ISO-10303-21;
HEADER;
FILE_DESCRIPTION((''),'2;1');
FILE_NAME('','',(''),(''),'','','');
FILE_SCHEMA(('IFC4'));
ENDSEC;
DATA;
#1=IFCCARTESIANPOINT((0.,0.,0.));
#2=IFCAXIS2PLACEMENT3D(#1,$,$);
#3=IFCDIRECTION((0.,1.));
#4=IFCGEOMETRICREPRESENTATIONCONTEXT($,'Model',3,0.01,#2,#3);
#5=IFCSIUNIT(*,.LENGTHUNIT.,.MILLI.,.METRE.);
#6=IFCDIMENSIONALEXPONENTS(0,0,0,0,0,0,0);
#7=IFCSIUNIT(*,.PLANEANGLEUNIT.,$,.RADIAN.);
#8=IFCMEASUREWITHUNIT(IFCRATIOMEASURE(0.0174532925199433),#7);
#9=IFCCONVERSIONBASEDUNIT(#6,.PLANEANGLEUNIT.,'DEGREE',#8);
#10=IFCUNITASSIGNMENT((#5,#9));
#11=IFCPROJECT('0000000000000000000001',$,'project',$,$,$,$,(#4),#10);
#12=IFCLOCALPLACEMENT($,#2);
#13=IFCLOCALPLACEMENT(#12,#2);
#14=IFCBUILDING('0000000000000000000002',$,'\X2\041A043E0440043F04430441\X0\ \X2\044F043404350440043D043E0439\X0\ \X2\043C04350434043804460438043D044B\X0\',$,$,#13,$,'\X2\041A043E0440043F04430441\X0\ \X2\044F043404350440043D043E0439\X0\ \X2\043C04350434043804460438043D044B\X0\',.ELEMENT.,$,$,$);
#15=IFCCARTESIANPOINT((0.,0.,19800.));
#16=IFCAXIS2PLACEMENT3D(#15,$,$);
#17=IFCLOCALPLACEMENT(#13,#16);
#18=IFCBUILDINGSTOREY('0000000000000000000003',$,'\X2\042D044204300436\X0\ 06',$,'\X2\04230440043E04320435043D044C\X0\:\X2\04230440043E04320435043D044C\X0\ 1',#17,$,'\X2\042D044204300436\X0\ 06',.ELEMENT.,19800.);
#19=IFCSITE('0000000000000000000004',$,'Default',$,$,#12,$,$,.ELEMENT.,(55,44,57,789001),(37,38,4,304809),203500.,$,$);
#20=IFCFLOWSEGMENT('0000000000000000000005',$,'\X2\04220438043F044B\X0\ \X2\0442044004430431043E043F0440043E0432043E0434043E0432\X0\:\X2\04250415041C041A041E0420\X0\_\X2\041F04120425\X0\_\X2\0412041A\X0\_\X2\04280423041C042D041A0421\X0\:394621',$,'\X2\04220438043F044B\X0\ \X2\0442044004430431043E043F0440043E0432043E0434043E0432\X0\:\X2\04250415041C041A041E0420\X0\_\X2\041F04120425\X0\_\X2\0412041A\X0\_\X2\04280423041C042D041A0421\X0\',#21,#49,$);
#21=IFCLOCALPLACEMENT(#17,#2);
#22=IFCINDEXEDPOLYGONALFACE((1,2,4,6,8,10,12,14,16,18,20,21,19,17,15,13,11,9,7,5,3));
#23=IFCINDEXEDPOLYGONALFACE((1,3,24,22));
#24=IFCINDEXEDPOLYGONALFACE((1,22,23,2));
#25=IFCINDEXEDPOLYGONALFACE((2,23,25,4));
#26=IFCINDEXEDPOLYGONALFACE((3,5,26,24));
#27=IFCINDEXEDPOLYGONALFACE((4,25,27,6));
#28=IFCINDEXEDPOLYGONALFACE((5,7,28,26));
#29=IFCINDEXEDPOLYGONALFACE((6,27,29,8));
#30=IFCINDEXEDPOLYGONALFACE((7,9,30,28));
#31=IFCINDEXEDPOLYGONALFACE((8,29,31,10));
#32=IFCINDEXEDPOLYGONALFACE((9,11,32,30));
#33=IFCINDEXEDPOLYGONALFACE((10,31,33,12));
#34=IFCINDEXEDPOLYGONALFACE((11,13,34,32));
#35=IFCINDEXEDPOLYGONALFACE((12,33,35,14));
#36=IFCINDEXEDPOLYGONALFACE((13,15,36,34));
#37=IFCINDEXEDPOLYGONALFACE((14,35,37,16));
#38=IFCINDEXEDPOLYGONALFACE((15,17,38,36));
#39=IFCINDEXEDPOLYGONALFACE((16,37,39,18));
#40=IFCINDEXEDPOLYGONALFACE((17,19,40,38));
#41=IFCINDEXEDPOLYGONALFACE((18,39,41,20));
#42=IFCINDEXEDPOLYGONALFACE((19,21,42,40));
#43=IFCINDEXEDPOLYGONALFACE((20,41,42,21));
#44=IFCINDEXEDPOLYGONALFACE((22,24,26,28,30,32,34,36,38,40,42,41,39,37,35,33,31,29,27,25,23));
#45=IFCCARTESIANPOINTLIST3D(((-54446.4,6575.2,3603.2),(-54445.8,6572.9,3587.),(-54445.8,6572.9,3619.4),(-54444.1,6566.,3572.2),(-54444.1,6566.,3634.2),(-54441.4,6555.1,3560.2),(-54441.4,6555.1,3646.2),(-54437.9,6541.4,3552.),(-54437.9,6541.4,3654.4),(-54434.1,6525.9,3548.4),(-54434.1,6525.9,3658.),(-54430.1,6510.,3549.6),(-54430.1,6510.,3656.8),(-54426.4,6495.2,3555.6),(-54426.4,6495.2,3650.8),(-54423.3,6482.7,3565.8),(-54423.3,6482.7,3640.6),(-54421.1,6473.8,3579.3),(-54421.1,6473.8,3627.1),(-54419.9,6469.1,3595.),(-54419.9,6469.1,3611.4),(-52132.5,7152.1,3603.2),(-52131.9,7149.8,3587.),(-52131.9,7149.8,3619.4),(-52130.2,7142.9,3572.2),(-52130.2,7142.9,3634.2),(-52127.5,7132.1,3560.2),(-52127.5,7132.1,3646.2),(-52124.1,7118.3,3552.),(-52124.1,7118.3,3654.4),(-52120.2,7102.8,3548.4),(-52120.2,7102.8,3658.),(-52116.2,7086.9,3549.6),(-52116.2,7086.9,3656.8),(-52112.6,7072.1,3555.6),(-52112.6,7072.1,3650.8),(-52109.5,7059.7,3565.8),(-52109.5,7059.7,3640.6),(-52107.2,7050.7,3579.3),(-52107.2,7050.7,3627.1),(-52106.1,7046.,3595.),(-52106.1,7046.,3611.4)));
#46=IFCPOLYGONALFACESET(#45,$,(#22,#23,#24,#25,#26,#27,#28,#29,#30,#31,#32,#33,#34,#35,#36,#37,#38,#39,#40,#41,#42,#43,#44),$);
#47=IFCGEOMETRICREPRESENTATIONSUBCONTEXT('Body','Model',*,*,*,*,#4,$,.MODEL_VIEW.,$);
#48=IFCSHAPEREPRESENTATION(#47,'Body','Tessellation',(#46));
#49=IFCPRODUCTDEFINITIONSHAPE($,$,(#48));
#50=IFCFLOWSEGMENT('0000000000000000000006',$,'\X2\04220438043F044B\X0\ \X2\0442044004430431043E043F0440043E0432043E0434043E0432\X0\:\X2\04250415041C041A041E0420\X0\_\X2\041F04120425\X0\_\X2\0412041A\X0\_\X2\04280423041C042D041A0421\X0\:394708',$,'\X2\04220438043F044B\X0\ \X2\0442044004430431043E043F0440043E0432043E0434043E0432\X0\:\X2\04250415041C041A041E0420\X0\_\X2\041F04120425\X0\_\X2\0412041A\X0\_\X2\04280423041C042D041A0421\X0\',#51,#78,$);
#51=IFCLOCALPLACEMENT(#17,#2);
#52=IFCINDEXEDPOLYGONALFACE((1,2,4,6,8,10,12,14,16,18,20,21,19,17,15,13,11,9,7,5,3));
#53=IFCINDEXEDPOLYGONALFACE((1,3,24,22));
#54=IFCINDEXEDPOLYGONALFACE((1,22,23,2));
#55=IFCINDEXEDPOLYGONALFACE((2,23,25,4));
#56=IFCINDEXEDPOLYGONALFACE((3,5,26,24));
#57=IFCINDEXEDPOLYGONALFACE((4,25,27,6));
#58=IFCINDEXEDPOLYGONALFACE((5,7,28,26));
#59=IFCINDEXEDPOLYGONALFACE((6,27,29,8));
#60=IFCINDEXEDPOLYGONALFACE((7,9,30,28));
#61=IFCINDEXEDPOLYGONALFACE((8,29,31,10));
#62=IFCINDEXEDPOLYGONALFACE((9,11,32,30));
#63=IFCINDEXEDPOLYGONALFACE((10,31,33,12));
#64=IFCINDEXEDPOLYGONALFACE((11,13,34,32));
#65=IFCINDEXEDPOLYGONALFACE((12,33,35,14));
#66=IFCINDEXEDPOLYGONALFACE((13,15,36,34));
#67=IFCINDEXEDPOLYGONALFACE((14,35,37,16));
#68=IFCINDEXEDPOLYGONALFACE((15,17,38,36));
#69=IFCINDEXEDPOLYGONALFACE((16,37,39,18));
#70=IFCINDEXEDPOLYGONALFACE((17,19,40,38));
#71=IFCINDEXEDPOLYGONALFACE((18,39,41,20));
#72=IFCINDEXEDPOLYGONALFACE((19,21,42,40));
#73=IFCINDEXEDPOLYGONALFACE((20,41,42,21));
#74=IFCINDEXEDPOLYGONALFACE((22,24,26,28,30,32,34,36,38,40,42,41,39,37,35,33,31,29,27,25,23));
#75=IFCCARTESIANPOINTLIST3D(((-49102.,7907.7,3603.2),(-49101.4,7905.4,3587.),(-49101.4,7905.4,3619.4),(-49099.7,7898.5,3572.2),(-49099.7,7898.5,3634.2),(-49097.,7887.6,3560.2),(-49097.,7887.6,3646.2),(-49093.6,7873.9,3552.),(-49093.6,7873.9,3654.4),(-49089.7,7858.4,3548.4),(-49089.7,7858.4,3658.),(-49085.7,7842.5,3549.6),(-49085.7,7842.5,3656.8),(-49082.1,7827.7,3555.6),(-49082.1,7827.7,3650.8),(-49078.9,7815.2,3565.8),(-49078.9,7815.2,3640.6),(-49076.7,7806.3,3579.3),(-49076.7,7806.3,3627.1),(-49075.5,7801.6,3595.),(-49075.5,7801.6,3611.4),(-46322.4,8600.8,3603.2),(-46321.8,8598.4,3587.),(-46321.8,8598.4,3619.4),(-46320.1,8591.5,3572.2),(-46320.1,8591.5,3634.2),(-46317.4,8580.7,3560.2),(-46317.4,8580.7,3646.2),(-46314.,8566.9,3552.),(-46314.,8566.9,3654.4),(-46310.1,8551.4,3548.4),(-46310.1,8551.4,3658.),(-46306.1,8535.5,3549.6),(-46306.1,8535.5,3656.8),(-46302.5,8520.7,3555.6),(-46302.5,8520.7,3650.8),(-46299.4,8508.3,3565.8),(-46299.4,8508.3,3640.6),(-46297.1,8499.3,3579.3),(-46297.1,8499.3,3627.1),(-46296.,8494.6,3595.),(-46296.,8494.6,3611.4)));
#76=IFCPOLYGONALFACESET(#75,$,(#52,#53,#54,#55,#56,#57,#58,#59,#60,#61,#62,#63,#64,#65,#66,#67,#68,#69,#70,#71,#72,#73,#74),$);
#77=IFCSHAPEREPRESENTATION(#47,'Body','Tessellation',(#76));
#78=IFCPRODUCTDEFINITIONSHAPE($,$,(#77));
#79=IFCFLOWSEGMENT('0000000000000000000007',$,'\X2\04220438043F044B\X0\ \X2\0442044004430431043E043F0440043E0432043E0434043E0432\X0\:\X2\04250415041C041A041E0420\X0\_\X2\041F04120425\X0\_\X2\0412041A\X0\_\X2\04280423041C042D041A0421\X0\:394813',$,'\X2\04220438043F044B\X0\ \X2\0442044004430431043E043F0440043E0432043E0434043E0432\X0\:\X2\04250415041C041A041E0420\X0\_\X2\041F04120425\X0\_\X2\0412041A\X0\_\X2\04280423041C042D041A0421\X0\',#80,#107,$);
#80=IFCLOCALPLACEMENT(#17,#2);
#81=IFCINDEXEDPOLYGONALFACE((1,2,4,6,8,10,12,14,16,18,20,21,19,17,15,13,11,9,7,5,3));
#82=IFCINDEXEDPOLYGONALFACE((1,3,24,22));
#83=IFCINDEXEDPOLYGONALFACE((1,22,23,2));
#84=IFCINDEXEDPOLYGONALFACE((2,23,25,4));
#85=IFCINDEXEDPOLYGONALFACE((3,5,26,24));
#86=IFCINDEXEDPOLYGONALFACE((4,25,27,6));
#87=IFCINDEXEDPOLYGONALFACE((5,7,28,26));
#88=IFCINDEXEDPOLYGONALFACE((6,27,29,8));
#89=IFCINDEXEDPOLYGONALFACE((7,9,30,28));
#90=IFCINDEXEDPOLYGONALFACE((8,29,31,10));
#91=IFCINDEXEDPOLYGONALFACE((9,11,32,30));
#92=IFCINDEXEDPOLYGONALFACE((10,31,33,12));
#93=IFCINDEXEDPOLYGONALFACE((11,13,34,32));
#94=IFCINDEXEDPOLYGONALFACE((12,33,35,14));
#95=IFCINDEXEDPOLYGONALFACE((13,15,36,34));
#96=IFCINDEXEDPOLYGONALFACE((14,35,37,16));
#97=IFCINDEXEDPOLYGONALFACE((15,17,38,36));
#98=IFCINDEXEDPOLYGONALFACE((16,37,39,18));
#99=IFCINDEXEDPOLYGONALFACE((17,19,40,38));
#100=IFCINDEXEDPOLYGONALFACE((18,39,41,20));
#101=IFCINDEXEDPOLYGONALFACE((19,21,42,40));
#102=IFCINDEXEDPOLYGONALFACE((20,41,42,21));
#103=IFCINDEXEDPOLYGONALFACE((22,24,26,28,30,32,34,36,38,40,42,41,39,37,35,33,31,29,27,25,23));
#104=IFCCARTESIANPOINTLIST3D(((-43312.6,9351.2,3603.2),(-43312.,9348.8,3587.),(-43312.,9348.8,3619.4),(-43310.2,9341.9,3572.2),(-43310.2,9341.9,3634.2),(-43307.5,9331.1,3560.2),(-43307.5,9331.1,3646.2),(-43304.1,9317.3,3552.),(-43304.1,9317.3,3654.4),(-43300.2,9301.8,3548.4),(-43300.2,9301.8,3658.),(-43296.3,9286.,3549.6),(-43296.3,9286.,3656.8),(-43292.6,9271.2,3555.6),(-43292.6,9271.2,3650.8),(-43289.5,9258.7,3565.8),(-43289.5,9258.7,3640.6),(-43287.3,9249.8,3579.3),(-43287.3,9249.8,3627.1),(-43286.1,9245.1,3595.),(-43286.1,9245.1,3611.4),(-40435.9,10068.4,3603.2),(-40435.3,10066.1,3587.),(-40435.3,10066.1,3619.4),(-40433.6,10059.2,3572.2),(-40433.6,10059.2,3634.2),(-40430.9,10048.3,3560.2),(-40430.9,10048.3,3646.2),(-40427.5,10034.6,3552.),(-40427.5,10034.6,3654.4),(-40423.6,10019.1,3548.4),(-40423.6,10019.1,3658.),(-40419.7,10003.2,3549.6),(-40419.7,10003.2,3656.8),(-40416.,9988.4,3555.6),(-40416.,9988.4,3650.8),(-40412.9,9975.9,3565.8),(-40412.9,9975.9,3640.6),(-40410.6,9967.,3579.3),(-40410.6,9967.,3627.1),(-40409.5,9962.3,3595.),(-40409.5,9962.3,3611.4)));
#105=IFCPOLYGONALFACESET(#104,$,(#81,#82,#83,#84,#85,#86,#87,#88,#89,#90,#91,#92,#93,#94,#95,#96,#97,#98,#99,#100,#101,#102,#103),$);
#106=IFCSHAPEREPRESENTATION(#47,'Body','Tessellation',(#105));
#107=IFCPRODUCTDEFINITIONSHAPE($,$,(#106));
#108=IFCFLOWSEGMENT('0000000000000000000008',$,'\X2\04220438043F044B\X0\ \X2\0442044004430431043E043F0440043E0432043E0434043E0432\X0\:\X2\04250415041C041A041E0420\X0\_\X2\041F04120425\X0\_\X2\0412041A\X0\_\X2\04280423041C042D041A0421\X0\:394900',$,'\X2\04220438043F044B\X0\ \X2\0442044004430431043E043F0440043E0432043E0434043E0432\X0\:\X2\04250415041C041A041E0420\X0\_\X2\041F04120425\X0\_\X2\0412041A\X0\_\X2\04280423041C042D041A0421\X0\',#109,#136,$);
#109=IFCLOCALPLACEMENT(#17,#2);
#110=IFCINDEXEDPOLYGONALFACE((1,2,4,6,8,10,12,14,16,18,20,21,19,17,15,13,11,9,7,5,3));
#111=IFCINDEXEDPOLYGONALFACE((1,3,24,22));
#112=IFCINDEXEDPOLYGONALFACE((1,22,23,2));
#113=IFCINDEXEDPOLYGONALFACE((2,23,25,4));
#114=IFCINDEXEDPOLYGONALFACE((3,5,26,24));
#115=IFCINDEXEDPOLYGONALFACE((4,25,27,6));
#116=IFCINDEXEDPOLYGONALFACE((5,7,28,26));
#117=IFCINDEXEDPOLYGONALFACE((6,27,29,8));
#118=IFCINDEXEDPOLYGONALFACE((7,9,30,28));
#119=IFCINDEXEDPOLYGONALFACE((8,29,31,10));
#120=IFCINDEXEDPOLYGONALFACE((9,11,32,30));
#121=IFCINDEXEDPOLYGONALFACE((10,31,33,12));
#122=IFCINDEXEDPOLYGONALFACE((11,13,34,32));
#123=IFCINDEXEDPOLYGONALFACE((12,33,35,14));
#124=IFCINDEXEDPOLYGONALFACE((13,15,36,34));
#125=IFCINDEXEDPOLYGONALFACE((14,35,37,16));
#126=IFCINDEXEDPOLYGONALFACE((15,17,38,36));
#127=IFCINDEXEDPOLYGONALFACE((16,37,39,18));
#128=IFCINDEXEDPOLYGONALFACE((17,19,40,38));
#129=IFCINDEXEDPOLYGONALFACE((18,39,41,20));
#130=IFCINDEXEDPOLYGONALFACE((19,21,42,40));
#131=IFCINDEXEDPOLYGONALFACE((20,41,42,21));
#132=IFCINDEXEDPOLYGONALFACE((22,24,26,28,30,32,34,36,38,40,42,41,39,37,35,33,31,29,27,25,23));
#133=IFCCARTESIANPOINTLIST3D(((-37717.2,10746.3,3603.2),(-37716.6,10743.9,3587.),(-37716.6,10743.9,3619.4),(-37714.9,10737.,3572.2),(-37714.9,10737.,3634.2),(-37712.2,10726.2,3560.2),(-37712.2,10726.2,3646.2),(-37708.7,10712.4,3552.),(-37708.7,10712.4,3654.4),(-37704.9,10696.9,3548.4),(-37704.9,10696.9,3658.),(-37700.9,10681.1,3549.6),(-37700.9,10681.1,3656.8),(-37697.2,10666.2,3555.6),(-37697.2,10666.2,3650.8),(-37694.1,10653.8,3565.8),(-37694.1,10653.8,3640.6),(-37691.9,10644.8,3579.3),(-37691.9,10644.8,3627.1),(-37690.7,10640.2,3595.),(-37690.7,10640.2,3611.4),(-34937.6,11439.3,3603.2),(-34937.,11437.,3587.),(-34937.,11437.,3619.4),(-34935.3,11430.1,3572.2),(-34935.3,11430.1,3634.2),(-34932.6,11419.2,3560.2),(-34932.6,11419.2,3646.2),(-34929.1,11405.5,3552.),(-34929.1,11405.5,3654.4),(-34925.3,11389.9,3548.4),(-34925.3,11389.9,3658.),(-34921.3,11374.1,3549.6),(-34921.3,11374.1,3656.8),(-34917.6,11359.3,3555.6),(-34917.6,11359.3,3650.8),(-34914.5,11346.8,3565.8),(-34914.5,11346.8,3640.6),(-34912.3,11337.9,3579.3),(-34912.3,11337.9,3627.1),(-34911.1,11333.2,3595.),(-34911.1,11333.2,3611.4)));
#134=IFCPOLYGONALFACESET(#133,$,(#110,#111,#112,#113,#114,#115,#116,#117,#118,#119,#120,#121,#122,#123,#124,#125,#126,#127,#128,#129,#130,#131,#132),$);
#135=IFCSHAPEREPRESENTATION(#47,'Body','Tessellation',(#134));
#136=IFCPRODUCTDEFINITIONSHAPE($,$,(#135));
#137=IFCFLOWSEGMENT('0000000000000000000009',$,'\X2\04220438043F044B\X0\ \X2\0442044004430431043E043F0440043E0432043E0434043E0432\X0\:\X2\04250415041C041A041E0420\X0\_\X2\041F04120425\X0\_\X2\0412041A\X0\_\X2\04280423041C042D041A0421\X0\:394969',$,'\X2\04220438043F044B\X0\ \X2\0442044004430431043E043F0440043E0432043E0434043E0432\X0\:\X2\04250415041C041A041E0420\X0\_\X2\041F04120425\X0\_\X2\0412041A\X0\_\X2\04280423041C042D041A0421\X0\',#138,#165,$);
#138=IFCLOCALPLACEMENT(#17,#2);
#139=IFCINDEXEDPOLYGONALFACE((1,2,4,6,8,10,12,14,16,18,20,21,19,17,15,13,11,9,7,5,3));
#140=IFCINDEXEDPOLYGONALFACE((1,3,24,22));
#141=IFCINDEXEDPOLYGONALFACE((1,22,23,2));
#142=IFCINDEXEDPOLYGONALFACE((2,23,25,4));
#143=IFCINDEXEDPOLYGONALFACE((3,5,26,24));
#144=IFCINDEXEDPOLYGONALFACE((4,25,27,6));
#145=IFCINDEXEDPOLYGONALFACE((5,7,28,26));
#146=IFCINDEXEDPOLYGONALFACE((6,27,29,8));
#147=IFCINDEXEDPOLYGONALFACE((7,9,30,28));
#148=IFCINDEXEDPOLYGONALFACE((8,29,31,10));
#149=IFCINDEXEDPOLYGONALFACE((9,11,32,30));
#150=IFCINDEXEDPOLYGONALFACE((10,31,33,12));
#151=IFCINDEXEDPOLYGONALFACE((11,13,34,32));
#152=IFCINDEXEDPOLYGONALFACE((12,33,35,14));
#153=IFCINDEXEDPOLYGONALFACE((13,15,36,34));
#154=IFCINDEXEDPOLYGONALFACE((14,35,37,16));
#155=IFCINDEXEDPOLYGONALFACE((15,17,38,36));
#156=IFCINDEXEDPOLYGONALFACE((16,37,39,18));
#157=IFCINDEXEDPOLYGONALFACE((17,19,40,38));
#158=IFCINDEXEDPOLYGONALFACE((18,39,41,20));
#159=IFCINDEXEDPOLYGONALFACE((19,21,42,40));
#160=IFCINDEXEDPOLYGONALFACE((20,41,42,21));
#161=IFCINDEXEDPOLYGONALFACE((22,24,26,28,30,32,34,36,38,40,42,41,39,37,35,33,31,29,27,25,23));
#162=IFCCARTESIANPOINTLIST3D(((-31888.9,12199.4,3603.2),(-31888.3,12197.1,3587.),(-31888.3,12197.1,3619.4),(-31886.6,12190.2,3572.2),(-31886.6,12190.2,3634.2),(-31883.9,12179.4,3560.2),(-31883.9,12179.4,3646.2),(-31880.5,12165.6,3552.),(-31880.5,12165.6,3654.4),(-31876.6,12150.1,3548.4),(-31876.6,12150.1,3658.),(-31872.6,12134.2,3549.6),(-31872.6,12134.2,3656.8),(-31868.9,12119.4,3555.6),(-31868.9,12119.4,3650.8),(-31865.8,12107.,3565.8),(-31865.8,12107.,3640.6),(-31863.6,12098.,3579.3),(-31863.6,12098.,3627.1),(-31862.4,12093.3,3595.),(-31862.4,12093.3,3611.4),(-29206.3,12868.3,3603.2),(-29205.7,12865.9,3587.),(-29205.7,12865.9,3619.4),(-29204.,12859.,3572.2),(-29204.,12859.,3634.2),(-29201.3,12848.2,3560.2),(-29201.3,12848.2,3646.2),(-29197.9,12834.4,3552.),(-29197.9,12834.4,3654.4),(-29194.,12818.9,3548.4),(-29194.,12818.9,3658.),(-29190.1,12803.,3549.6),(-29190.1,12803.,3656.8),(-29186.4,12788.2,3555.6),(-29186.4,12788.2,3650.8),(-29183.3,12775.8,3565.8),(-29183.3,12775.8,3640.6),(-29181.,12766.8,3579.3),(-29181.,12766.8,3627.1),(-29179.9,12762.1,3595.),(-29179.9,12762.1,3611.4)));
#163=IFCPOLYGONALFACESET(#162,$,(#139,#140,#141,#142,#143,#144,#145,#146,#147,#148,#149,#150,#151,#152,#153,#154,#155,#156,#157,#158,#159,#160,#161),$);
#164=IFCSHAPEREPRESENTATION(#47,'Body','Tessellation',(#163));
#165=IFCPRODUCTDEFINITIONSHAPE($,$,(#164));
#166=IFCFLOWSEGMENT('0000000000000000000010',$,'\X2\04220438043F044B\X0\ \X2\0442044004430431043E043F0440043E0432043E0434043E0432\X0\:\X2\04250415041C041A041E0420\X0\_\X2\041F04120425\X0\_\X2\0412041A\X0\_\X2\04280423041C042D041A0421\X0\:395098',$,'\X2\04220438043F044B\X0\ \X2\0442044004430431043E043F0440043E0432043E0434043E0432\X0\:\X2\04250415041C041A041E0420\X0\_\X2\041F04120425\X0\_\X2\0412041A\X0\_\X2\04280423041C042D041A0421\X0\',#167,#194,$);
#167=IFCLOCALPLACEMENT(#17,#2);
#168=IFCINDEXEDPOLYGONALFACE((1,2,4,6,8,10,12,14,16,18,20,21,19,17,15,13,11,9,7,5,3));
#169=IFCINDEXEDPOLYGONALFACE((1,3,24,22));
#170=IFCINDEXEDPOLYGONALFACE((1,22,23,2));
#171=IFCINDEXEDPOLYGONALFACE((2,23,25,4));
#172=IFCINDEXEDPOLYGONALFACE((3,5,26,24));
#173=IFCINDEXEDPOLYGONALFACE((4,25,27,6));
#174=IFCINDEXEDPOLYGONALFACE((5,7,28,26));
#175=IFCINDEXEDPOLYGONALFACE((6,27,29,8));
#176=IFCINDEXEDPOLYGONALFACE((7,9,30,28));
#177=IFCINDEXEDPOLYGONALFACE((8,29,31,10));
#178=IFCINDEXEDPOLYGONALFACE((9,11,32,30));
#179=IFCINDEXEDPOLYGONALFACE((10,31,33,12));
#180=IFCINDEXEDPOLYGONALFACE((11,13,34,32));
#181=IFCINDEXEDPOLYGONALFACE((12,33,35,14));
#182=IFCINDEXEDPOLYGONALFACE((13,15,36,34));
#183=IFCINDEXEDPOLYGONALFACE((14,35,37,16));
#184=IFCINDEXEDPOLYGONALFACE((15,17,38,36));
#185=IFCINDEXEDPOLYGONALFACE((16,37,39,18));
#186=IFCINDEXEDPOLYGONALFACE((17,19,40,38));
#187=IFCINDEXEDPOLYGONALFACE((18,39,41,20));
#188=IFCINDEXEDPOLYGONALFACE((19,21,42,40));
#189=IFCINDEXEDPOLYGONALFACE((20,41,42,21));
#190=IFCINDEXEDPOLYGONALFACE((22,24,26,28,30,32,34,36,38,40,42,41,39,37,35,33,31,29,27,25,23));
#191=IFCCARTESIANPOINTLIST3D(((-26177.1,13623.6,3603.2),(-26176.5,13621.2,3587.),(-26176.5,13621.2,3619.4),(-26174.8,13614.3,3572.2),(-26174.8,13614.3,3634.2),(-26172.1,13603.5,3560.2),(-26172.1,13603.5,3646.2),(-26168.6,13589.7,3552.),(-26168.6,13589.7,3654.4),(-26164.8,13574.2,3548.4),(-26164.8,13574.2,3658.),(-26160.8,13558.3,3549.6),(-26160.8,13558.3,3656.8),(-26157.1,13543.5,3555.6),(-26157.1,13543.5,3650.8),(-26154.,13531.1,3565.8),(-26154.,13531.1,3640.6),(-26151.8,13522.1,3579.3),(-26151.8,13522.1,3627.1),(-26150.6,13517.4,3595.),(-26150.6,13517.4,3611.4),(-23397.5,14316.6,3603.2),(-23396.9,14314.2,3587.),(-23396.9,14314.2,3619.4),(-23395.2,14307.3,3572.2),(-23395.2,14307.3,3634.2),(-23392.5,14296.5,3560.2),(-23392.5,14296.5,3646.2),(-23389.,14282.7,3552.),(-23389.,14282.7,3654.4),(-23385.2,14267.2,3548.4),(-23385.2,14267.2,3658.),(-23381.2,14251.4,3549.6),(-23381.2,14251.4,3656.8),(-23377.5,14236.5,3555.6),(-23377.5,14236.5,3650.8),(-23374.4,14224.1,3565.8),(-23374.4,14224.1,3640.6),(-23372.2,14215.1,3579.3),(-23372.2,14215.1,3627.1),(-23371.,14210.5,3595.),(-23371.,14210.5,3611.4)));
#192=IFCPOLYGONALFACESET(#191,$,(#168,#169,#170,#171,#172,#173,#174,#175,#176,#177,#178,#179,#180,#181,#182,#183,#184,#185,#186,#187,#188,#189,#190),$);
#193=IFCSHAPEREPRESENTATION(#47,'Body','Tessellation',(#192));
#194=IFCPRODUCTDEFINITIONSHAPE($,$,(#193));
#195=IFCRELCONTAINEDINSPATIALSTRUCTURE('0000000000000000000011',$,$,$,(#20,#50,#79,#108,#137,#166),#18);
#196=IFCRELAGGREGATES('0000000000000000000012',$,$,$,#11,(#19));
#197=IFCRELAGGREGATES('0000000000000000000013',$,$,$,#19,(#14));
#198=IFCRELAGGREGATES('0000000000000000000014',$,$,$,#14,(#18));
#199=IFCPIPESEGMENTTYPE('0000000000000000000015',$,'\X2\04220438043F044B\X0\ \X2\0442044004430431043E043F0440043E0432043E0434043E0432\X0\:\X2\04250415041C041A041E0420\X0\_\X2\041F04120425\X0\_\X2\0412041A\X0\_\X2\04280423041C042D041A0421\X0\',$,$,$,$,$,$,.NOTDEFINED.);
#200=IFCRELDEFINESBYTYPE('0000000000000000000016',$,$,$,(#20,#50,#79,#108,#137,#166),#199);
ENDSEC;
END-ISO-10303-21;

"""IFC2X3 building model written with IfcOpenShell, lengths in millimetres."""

from ifc_helpers import new_model, entity, si_unit, converted_unit, direction, frame, frame_2d, origin, origin_2d_with_axis, place, context, subcontext, project, spatial, circle, extrude, type_object, element, save


model = new_model("IFC2X3")

# Units and contexts
model_context = context("Model", 3, precision=0.01, world=origin(), true_north=direction((0.0, 1.0)))
body_context = subcontext(model_context, "Body", "Model", "MODEL_VIEW")
ifc_project = project(units=[si_unit("LENGTHUNIT", "METRE", prefix="MILLI"), converted_unit("PLANEANGLEUNIT", "DEGREE", entity("IfcRatioMeasure", 0.0174532925199433), si_unit("PLANEANGLEUNIT", "RADIAN"), dimensions=[0, 0, 0, 0, 0, 0, 0])], contexts=[model_context])

# Site, building, storey
site_placement = place(None, frame((0.0, 0.0, 0.0)))
site = spatial("IfcSite", under=ifc_project, at=site_placement, Name="Default", CompositionType="ELEMENT", RefLatitude=(55, 44, 57, 789001), RefLongitude=(37, 38, 4, 304809), RefElevation=203500.0)
building_placement = place(site_placement, origin())
building = spatial("IfcBuilding", under=site, at=building_placement, Name="Корпус ядерной медицины", LongName="Корпус ядерной медицины", CompositionType="ELEMENT")
storey_placement = place(building_placement, frame((0.0, 0.0, 19800.0)))
storey = spatial("IfcBuildingStorey", under=building, at=storey_placement, Name="Этаж 06", ObjectType="Уровень:Уровень 1", LongName="Этаж 06", CompositionType="ELEMENT", Elevation=19800.0)

# Flow segments
pipe_segment_type = type_object("IfcPipeSegmentType", Name="Типы трубопроводов:ХЕМКОР_ПВХ_ВК_ШУМЭКС", PredefinedType="NOTDEFINED")
flow_segment_1_placement = place(storey_placement, frame((-54448.0, 6466.9, 3546.6)))
element("IfcFlowSegment", 1, at=flow_segment_1_placement, inside=storey, type_object=pipe_segment_type, Name="Типы трубопроводов:ХЕМКОР_ПВХ_ВК_ШУМЭКС:394621", ObjectType="Типы трубопроводов:ХЕМКОР_ПВХ_ВК_ШУМЭКС", context=body_context, shape_type="SweptSolid", body=[
    extrude(circle(Radius=55.0, at=origin_2d_with_axis()), frame((14.9, 55.0, 56.6), z_axis=(0.970296, 0.241922, 0.0), x_axis=(-0.241922, 0.970296, 0.0)), (0.0, 0.0, 1.0), 2384.7),
])
flow_segment_2_placement = place(storey_placement, frame((-49103.6, 7799.4, 3546.6)))
element("IfcFlowSegment", 2, at=flow_segment_2_placement, inside=storey, type_object=pipe_segment_type, Name="Типы трубопроводов:ХЕМКОР_ПВХ_ВК_ШУМЭКС:394708", ObjectType="Типы трубопроводов:ХЕМКОР_ПВХ_ВК_ШУМЭКС", context=body_context, shape_type="SweptSolid", body=[
    extrude(circle(Radius=55.0, at=frame_2d((0.0, 0.0), x_axis=(1.0, 0.0))), frame((14.9, 55.0, 56.6), z_axis=(0.970296, 0.241922, 0.0), x_axis=(-0.241922, 0.970296, 0.0)), (0.0, 0.0, 1.0), 2864.7),
])
flow_segment_3_placement = place(storey_placement, frame((-43314.2, 9242.9, 3546.6)))
element("IfcFlowSegment", 3, at=flow_segment_3_placement, inside=storey, type_object=pipe_segment_type, Name="Типы трубопроводов:ХЕМКОР_ПВХ_ВК_ШУМЭКС:394813", ObjectType="Типы трубопроводов:ХЕМКОР_ПВХ_ВК_ШУМЭКС", context=body_context, shape_type="SweptSolid", body=[
    extrude(circle(Radius=55.0, at=frame_2d((0.0, 0.0), x_axis=(1.0, 0.0))), frame((14.9, 55.0, 56.6), z_axis=(0.970296, 0.241922, 0.0), x_axis=(-0.241922, 0.970296, 0.0)), (0.0, 0.0, 1.0), 2964.7),
])
flow_segment_4_placement = place(storey_placement, frame((-37718.8, 10638.0, 3546.6)))
element("IfcFlowSegment", 4, at=flow_segment_4_placement, inside=storey, type_object=pipe_segment_type, Name="Типы трубопроводов:ХЕМКОР_ПВХ_ВК_ШУМЭКС:394900", ObjectType="Типы трубопроводов:ХЕМКОР_ПВХ_ВК_ШУМЭКС", context=body_context, shape_type="SweptSolid", body=[
    extrude(circle(Radius=55.0, at=origin_2d_with_axis()), frame((14.9, 55.0, 56.6), z_axis=(0.970296, 0.241922, 0.0), x_axis=(-0.241922, 0.970296, 0.0)), (0.0, 0.0, 1.0), 2864.7),
])
flow_segment_5_placement = place(storey_placement, frame((-31890.5, 12091.1, 3546.6)))
element("IfcFlowSegment", 5, at=flow_segment_5_placement, inside=storey, type_object=pipe_segment_type, Name="Типы трубопроводов:ХЕМКОР_ПВХ_ВК_ШУМЭКС:394969", ObjectType="Типы трубопроводов:ХЕМКОР_ПВХ_ВК_ШУМЭКС", context=body_context, shape_type="SweptSolid", body=[
    extrude(circle(Radius=55.0, at=origin_2d_with_axis()), frame((14.9, 55.0, 56.6), z_axis=(0.970296, 0.241922, 0.0), x_axis=(-0.241922, 0.970296, 0.0)), (0.0, 0.0, 1.0), 2764.7),
])
flow_segment_6_placement = place(storey_placement, frame((-26178.7, 13515.2, 3546.6)))
element("IfcFlowSegment", 6, at=flow_segment_6_placement, inside=storey, type_object=pipe_segment_type, Name="Типы трубопроводов:ХЕМКОР_ПВХ_ВК_ШУМЭКС:395098", ObjectType="Типы трубопроводов:ХЕМКОР_ПВХ_ВК_ШУМЭКС", context=body_context, shape_type="SweptSolid", body=[
    extrude(circle(Radius=55.0, at=origin_2d_with_axis()), frame((14.9, 55.0, 56.6), z_axis=(0.970296, 0.241922, 0.0), x_axis=(-0.241922, 0.970296, 0.0)), (0.0, 0.0, 1.0), 2864.7),
])

save(model, "model.ifc")
